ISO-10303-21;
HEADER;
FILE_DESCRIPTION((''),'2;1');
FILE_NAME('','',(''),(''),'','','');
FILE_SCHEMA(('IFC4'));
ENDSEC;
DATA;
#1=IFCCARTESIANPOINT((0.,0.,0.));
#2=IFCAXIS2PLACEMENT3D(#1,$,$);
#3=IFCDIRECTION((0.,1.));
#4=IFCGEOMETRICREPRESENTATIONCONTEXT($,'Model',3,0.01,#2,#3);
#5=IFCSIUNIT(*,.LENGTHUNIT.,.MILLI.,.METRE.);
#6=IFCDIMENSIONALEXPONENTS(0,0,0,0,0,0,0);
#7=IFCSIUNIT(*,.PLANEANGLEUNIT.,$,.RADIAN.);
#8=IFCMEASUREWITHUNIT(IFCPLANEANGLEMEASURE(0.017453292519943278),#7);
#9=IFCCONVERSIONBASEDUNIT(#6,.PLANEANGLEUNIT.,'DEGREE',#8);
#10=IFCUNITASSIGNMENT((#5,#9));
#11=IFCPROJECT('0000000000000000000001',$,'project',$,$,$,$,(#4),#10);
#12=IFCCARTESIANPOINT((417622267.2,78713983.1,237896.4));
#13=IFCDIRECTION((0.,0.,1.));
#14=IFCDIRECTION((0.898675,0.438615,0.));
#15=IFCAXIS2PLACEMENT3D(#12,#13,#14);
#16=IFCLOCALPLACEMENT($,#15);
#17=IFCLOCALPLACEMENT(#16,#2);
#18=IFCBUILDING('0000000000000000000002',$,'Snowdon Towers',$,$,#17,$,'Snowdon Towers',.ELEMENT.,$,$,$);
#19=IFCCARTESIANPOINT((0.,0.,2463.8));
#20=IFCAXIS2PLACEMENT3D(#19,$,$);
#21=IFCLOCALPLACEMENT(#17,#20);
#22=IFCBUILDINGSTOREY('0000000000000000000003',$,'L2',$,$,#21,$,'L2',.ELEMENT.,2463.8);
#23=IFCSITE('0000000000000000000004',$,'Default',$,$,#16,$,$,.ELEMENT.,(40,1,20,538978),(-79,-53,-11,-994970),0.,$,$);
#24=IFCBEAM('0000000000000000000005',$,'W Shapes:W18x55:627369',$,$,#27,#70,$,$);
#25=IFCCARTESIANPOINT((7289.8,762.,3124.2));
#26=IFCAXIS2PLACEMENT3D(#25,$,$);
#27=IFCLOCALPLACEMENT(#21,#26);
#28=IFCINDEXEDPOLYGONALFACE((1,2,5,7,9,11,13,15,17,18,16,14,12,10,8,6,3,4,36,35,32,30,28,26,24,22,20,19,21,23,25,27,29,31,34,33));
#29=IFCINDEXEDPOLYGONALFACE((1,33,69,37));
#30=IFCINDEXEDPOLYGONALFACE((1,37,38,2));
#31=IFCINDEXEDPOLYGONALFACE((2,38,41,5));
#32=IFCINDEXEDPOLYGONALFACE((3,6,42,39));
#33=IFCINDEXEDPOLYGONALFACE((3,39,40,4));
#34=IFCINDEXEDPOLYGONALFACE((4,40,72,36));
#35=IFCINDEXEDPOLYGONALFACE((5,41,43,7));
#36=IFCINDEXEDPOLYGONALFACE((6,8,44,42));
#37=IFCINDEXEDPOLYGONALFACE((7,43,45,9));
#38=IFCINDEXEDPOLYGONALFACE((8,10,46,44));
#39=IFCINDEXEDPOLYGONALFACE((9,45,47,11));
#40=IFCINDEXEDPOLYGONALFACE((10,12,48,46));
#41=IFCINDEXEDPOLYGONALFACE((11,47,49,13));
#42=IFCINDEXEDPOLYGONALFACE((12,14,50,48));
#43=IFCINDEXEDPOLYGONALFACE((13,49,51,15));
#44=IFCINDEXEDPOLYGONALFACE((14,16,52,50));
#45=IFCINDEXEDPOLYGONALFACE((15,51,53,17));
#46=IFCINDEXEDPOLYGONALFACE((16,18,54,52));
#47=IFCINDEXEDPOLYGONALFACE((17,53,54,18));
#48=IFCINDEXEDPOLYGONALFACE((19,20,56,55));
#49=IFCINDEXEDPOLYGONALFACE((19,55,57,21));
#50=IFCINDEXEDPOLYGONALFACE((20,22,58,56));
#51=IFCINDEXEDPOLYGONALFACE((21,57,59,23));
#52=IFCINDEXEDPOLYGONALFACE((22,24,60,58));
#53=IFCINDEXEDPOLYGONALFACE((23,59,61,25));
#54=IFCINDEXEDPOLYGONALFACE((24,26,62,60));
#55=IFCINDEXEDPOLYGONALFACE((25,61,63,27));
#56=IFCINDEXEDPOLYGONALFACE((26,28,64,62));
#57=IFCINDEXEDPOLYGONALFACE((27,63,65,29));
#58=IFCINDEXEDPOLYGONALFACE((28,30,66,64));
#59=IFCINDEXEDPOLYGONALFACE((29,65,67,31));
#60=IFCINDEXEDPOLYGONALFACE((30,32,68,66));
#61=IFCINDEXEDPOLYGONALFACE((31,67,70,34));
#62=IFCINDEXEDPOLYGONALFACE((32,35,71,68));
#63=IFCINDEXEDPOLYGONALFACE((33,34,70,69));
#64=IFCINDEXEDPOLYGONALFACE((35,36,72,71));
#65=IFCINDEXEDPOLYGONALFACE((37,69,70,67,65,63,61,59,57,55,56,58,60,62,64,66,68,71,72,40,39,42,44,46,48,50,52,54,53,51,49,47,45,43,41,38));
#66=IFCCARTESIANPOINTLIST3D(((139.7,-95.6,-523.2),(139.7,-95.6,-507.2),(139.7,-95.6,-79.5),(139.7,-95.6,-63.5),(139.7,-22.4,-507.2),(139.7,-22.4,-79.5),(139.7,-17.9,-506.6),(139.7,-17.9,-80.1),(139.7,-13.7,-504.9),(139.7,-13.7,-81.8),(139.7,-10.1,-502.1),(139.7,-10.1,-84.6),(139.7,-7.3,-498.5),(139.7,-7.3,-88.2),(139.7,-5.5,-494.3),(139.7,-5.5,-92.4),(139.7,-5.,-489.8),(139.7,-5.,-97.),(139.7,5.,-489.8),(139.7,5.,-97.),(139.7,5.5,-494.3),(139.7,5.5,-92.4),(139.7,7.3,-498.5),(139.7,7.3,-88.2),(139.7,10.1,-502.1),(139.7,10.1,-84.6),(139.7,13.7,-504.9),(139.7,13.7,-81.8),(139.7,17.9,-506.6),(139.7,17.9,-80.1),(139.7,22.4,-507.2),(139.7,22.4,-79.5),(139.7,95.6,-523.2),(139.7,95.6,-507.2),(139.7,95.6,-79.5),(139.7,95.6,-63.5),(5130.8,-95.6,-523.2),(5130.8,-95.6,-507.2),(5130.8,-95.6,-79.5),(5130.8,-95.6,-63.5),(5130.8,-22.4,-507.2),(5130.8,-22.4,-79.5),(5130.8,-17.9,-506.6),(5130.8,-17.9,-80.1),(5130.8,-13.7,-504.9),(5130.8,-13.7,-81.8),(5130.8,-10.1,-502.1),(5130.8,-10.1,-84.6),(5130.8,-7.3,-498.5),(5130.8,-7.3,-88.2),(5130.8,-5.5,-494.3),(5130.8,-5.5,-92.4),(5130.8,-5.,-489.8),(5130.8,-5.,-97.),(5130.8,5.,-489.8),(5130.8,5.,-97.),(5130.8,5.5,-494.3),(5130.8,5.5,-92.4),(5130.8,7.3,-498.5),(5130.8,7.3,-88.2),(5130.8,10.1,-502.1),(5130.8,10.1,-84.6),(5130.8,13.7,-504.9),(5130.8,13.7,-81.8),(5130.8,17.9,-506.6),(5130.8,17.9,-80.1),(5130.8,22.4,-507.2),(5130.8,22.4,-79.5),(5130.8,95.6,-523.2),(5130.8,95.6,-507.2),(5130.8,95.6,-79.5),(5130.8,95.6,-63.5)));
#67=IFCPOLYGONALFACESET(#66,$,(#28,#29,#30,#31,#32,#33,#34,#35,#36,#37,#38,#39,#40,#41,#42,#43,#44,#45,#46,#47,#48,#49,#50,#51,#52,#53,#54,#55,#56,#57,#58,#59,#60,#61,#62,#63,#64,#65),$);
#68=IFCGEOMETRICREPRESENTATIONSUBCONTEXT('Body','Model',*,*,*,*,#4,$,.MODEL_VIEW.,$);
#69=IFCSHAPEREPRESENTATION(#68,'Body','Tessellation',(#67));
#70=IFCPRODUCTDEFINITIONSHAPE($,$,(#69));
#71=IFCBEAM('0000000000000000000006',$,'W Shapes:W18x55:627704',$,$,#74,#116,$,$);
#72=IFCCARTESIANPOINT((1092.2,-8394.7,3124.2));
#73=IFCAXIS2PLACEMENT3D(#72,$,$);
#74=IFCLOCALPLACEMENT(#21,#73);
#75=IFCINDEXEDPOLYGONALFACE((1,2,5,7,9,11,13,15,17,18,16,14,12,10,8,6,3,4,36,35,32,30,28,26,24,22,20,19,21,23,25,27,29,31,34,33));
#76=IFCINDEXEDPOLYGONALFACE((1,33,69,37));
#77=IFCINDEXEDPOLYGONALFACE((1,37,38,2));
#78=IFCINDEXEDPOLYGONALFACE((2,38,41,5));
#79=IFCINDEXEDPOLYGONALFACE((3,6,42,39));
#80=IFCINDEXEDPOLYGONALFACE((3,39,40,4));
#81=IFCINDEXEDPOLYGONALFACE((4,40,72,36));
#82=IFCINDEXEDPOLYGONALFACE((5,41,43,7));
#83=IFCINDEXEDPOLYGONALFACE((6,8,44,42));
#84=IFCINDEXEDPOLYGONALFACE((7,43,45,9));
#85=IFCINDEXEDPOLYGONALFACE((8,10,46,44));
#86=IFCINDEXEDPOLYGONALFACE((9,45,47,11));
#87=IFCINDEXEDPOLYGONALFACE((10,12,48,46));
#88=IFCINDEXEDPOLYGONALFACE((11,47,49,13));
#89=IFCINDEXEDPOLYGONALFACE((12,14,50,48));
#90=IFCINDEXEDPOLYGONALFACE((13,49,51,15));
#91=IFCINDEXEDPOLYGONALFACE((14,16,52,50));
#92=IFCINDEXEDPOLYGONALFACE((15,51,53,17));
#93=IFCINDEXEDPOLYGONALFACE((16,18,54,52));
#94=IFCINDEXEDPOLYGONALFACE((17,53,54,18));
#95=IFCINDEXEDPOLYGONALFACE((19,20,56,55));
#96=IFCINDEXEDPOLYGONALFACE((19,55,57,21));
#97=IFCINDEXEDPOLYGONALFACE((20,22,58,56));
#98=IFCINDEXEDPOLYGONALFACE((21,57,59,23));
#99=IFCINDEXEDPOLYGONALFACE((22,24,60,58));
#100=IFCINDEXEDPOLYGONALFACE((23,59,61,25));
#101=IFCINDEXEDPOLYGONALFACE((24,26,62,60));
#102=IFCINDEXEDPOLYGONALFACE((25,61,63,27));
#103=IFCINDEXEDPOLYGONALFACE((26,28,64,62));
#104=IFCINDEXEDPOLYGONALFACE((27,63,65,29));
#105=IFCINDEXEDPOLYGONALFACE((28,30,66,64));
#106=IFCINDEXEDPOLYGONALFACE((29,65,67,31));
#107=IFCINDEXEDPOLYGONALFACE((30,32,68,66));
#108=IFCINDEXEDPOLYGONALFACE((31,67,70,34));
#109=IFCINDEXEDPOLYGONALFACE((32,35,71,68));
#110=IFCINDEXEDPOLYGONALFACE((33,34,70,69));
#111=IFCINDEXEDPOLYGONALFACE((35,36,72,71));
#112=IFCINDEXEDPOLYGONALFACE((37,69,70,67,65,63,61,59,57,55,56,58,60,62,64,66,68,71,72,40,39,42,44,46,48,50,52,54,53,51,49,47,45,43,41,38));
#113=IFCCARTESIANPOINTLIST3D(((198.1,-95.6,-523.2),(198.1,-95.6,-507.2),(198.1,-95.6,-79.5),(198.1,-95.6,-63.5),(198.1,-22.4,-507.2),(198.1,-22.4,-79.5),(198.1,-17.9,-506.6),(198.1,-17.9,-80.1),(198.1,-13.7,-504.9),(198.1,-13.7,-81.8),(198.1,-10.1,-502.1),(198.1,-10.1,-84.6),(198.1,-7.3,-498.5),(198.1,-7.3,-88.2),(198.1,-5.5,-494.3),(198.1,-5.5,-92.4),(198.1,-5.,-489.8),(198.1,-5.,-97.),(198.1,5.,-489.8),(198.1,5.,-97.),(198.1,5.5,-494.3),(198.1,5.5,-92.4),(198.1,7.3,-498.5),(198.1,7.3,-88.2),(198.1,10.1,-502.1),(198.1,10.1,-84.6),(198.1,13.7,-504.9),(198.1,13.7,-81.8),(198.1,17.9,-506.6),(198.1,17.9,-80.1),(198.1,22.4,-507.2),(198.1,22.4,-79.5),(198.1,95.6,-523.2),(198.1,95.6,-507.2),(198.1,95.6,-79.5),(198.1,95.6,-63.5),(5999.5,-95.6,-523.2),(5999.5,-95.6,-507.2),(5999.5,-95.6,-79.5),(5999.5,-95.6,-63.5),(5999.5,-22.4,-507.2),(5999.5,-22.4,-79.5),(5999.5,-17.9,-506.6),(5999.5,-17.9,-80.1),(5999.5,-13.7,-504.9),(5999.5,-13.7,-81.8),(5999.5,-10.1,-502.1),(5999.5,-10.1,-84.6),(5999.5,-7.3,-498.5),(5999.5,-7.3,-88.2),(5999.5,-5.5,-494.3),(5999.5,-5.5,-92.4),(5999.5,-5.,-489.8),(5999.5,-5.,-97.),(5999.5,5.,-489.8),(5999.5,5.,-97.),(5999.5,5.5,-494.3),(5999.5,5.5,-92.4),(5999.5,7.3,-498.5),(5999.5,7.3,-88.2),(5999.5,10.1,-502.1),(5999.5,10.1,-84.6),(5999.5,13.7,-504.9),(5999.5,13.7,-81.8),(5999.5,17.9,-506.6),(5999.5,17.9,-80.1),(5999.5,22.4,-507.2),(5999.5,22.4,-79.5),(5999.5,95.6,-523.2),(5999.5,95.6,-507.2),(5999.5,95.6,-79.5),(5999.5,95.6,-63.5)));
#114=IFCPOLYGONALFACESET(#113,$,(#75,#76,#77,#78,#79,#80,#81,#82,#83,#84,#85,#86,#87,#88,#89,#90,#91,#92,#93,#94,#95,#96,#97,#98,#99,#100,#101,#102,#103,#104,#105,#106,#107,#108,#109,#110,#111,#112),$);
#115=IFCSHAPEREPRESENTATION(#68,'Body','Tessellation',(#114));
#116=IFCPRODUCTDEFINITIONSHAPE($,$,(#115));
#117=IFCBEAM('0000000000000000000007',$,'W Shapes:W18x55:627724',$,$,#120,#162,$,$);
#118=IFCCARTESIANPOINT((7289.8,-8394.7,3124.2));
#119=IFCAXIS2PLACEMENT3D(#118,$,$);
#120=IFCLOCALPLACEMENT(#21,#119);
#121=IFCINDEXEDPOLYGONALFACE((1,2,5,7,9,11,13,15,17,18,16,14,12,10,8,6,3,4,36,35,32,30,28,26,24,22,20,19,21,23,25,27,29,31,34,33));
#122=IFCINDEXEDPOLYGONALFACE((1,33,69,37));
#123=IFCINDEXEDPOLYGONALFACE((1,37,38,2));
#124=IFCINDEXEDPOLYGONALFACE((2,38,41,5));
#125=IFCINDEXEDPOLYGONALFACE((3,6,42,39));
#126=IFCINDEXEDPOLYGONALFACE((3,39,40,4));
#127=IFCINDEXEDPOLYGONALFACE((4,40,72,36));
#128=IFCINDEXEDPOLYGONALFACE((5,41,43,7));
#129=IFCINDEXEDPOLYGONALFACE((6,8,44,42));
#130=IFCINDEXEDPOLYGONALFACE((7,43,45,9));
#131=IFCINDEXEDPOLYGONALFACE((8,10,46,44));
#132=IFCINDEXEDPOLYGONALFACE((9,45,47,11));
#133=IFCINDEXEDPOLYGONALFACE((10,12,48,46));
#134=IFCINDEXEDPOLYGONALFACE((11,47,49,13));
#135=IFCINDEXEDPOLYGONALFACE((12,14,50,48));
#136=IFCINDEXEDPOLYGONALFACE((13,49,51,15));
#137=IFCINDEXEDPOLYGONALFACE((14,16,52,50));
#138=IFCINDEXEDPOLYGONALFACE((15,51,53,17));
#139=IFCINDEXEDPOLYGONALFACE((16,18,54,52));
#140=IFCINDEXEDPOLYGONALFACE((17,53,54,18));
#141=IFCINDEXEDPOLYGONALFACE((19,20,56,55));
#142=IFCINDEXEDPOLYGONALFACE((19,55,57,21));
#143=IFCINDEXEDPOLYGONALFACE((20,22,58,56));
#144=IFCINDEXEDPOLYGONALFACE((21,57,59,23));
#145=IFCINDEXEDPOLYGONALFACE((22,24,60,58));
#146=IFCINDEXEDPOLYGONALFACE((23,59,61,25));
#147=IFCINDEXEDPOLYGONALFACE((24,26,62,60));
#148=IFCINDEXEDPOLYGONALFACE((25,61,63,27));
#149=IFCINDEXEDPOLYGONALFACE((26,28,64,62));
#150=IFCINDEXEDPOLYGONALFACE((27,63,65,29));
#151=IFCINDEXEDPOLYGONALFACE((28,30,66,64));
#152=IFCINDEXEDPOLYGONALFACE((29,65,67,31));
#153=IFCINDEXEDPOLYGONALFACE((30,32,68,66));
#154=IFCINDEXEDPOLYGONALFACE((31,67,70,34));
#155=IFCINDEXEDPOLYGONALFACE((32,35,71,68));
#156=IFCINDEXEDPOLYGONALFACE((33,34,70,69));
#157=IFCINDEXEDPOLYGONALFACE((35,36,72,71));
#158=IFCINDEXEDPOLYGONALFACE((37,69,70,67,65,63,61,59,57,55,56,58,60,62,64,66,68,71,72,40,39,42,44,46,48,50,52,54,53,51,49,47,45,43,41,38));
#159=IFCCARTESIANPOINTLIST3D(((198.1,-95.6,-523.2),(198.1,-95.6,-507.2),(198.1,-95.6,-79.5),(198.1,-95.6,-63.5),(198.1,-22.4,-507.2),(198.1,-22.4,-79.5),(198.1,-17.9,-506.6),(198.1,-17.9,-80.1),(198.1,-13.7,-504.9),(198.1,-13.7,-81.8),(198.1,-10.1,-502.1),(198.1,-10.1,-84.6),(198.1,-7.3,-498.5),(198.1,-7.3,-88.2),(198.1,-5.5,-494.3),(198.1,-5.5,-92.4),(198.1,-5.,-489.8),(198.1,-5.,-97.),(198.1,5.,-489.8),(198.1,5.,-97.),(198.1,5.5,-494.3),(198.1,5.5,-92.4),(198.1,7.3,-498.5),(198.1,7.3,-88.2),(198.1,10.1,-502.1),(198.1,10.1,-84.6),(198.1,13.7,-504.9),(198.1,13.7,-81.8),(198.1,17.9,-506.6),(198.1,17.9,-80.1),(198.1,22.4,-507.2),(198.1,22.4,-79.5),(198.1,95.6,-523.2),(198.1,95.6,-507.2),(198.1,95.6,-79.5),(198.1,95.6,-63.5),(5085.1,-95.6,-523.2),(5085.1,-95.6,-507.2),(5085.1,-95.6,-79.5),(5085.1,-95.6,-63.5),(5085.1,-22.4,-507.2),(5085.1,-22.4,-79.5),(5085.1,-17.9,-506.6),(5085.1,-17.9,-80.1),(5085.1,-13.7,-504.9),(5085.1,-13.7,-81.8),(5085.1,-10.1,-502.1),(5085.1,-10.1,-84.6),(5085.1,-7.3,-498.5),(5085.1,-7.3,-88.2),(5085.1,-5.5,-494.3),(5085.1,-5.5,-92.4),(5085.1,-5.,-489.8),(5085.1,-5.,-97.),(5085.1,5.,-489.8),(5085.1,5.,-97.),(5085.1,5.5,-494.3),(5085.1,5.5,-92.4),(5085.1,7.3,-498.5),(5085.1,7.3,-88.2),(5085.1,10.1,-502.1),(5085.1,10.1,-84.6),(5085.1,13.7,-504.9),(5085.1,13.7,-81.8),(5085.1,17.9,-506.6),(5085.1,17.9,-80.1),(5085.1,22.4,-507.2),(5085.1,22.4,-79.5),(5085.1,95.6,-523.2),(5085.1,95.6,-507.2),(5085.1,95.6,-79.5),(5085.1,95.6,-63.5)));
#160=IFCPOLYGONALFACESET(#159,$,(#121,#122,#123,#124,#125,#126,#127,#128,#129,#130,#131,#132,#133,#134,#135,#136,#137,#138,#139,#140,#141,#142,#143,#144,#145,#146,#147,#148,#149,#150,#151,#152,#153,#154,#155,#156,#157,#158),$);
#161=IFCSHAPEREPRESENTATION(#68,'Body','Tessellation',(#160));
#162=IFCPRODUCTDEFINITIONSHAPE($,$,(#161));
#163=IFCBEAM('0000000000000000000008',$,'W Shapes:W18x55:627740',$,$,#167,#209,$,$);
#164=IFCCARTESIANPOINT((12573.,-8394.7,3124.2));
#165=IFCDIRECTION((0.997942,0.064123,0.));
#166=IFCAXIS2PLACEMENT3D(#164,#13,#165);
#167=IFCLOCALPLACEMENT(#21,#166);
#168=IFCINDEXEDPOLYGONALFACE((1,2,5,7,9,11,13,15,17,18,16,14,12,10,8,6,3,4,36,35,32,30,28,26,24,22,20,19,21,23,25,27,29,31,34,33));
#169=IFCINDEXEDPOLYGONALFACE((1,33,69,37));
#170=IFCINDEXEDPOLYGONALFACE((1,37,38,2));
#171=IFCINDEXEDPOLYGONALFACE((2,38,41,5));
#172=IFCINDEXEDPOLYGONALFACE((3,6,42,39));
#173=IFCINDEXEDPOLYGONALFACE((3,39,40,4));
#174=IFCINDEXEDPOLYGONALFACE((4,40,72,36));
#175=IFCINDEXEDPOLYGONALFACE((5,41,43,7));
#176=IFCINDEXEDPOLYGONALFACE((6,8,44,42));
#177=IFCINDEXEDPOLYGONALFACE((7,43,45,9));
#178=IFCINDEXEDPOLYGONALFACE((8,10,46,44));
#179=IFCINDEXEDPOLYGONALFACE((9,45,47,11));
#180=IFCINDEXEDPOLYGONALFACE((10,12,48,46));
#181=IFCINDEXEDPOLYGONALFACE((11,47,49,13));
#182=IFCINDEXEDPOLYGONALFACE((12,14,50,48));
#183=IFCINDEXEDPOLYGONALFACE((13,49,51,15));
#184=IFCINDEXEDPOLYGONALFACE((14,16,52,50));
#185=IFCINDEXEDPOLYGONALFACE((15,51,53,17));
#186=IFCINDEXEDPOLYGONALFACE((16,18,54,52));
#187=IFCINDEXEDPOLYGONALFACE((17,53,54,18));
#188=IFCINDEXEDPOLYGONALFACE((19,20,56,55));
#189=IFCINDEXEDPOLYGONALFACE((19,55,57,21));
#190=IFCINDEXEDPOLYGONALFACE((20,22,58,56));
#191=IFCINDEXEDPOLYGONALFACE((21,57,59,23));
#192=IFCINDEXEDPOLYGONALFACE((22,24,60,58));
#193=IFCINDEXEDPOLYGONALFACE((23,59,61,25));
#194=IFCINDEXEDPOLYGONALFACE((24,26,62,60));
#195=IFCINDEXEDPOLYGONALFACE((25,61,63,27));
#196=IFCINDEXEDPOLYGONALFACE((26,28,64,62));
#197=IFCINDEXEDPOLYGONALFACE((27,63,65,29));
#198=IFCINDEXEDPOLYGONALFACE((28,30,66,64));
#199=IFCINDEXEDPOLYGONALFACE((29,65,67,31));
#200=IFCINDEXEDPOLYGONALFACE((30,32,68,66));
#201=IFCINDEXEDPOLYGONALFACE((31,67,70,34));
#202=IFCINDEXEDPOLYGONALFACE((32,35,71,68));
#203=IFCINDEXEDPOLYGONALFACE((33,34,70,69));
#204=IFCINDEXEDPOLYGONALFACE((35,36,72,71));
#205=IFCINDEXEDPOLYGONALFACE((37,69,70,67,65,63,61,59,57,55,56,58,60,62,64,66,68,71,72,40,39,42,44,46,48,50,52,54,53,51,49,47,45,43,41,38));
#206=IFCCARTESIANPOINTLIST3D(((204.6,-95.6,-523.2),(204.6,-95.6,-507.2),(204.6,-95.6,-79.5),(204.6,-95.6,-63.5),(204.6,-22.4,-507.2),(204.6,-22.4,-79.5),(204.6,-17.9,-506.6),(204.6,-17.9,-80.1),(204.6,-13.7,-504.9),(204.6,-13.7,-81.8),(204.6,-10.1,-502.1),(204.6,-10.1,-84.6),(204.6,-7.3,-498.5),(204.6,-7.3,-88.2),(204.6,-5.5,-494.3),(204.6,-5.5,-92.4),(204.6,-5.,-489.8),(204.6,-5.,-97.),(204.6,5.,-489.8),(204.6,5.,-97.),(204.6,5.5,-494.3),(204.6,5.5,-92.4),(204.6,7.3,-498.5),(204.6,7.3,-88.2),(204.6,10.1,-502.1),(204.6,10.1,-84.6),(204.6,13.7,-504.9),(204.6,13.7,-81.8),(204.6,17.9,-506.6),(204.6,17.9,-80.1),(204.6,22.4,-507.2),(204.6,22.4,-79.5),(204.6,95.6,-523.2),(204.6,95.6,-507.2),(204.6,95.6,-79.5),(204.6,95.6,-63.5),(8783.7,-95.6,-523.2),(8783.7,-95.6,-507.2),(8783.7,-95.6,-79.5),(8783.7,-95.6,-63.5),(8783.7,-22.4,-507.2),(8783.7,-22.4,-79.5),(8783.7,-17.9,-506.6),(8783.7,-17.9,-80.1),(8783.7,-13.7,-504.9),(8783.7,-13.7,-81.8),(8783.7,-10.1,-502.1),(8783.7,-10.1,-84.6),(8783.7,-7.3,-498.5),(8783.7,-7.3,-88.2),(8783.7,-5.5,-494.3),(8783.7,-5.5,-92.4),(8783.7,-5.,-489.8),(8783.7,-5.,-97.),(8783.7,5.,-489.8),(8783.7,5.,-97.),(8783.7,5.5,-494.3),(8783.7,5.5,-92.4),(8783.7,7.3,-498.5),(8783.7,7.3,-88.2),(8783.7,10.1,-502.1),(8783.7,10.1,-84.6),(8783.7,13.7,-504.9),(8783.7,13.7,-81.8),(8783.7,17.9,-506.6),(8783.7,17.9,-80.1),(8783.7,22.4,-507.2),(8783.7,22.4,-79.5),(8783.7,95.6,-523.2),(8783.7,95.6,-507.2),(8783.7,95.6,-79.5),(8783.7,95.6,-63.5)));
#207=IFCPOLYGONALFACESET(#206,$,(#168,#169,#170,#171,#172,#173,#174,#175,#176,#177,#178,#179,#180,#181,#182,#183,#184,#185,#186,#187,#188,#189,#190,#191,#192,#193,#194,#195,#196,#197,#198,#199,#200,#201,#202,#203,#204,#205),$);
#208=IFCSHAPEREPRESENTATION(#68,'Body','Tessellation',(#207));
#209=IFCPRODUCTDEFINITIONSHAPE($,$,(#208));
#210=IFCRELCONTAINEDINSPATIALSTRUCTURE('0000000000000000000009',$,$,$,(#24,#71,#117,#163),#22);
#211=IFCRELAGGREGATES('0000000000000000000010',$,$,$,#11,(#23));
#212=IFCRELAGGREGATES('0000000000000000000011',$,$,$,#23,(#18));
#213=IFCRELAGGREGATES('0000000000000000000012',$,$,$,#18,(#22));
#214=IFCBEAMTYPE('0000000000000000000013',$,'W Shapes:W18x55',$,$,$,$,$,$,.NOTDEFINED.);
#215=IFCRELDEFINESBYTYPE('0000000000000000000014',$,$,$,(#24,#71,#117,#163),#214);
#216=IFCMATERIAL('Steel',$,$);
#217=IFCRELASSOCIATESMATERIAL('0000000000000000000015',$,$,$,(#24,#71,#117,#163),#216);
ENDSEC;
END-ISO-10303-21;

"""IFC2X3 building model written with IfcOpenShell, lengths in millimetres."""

from ifc_helpers import new_model, entity, si_unit, converted_unit, direction, frame, frame_2d, origin, place, context, subcontext, project, spatial, i_section, extrude, material, type_object, element, save


model = new_model("IFC2X3")

# Units and contexts
model_context = context("Model", 3, precision=0.01, world=origin(), true_north=direction((0.0, 1.0)))
body_context = subcontext(model_context, "Body", "Model", "MODEL_VIEW")
ifc_project = project(units=[si_unit("LENGTHUNIT", "METRE", prefix="MILLI"), converted_unit("PLANEANGLEUNIT", "DEGREE", entity("IfcPlaneAngleMeasure", 0.017453292519943278), si_unit("PLANEANGLEUNIT", "RADIAN"), dimensions=[0, 0, 0, 0, 0, 0, 0])], contexts=[model_context])

# Site, building, storey
site_placement = place(None, frame((417622267.2, 78713983.1, 237896.4), z_axis=(0.0, 0.0, 1.0), x_axis=(0.898675, 0.438615, 0.0)))
site = spatial("IfcSite", under=ifc_project, at=site_placement, Name="Default", CompositionType="ELEMENT", RefLatitude=(40, 1, 20, 538978), RefLongitude=(-79, -53, -11, -994970), RefElevation=0.0)
building_placement = place(site_placement, origin())
building = spatial("IfcBuilding", under=site, at=building_placement, Name="Snowdon Towers", LongName="Snowdon Towers", CompositionType="ELEMENT")
storey_placement = place(building_placement, frame((0.0, 0.0, 2463.8)))
storey = spatial("IfcBuildingStorey", under=building, at=storey_placement, Name="L2", LongName="L2", CompositionType="ELEMENT", Elevation=2463.8)

# Shared definitions
ifc_material_1 = material(Name="Steel")

# Beams
beam_type_1 = type_object("IfcBeamType", Name="W Shapes:W18x55", PredefinedType="NOTDEFINED")
beam_1_placement = place(storey_placement, frame((7289.8, 762.0, 3124.2)))
element("IfcBeam", 1, at=beam_1_placement, inside=storey, type_object=beam_type_1, material=ifc_material_1, Name="W Shapes:W18x55:627369", context=body_context, shape_type="SweptSolid", body=[
    extrude(i_section(OverallWidth=191.3, OverallDepth=459.7, WebThickness=9.9, FlangeThickness=16.0, FilletRadius=17.5, at=frame_2d((0.0, 0.0), x_axis=(0.0, 1.0))), frame((139.7, 0.0, -293.4), z_axis=(1.0, 0.0, 0.0), x_axis=(0.0, 0.0, -1.0)), (0.0, 0.0, 1.0), 4991.1),
])
beam_2_placement = place(storey_placement, frame((1092.2, -8394.7, 3124.2)))
element("IfcBeam", 2, at=beam_2_placement, inside=storey, type_object=beam_type_1, material=ifc_material_1, Name="W Shapes:W18x55:627704", context=body_context, shape_type="SweptSolid", body=[
    extrude(i_section(OverallWidth=191.3, OverallDepth=459.7, WebThickness=9.9, FlangeThickness=16.0, FilletRadius=17.5, at=frame_2d((0.0, 0.0), x_axis=(0.0, 1.0))), frame((198.1, 0.0, -293.4), z_axis=(1.0, 0.0, 0.0), x_axis=(0.0, 0.0, -1.0)), (0.0, 0.0, 1.0), 5801.4),
])
beam_3_placement = place(storey_placement, frame((7289.8, -8394.7, 3124.2)))
element("IfcBeam", 3, at=beam_3_placement, inside=storey, type_object=beam_type_1, material=ifc_material_1, Name="W Shapes:W18x55:627724", context=body_context, shape_type="SweptSolid", body=[
    extrude(i_section(OverallWidth=191.3, OverallDepth=459.7, WebThickness=9.9, FlangeThickness=16.0, FilletRadius=17.5, at=frame_2d((0.0, 0.0), x_axis=(0.0, 1.0))), frame((198.1, 0.0, -293.4), z_axis=(1.0, 0.0, 0.0), x_axis=(0.0, 0.0, -1.0)), (0.0, 0.0, 1.0), 4887.0),
])
beam_4_placement = place(storey_placement, frame((12573.0, -8394.7, 3124.2), z_axis=(0.0, 0.0, 1.0), x_axis=(0.997942, 0.064123, 0.0)))
element("IfcBeam", 4, at=beam_4_placement, inside=storey, type_object=beam_type_1, material=ifc_material_1, Name="W Shapes:W18x55:627740", context=body_context, shape_type="SweptSolid", body=[
    extrude(i_section(OverallWidth=191.3, OverallDepth=459.7, WebThickness=9.9, FlangeThickness=16.0, FilletRadius=17.5, at=frame_2d((0.0, 0.0), x_axis=(0.0, 1.0))), frame((204.6, 0.0, -293.4), z_axis=(1.0, 0.0, 0.0), x_axis=(0.0, 0.0, -1.0)), (0.0, 0.0, 1.0), 8579.1),
])

save(model, "model.ifc")
